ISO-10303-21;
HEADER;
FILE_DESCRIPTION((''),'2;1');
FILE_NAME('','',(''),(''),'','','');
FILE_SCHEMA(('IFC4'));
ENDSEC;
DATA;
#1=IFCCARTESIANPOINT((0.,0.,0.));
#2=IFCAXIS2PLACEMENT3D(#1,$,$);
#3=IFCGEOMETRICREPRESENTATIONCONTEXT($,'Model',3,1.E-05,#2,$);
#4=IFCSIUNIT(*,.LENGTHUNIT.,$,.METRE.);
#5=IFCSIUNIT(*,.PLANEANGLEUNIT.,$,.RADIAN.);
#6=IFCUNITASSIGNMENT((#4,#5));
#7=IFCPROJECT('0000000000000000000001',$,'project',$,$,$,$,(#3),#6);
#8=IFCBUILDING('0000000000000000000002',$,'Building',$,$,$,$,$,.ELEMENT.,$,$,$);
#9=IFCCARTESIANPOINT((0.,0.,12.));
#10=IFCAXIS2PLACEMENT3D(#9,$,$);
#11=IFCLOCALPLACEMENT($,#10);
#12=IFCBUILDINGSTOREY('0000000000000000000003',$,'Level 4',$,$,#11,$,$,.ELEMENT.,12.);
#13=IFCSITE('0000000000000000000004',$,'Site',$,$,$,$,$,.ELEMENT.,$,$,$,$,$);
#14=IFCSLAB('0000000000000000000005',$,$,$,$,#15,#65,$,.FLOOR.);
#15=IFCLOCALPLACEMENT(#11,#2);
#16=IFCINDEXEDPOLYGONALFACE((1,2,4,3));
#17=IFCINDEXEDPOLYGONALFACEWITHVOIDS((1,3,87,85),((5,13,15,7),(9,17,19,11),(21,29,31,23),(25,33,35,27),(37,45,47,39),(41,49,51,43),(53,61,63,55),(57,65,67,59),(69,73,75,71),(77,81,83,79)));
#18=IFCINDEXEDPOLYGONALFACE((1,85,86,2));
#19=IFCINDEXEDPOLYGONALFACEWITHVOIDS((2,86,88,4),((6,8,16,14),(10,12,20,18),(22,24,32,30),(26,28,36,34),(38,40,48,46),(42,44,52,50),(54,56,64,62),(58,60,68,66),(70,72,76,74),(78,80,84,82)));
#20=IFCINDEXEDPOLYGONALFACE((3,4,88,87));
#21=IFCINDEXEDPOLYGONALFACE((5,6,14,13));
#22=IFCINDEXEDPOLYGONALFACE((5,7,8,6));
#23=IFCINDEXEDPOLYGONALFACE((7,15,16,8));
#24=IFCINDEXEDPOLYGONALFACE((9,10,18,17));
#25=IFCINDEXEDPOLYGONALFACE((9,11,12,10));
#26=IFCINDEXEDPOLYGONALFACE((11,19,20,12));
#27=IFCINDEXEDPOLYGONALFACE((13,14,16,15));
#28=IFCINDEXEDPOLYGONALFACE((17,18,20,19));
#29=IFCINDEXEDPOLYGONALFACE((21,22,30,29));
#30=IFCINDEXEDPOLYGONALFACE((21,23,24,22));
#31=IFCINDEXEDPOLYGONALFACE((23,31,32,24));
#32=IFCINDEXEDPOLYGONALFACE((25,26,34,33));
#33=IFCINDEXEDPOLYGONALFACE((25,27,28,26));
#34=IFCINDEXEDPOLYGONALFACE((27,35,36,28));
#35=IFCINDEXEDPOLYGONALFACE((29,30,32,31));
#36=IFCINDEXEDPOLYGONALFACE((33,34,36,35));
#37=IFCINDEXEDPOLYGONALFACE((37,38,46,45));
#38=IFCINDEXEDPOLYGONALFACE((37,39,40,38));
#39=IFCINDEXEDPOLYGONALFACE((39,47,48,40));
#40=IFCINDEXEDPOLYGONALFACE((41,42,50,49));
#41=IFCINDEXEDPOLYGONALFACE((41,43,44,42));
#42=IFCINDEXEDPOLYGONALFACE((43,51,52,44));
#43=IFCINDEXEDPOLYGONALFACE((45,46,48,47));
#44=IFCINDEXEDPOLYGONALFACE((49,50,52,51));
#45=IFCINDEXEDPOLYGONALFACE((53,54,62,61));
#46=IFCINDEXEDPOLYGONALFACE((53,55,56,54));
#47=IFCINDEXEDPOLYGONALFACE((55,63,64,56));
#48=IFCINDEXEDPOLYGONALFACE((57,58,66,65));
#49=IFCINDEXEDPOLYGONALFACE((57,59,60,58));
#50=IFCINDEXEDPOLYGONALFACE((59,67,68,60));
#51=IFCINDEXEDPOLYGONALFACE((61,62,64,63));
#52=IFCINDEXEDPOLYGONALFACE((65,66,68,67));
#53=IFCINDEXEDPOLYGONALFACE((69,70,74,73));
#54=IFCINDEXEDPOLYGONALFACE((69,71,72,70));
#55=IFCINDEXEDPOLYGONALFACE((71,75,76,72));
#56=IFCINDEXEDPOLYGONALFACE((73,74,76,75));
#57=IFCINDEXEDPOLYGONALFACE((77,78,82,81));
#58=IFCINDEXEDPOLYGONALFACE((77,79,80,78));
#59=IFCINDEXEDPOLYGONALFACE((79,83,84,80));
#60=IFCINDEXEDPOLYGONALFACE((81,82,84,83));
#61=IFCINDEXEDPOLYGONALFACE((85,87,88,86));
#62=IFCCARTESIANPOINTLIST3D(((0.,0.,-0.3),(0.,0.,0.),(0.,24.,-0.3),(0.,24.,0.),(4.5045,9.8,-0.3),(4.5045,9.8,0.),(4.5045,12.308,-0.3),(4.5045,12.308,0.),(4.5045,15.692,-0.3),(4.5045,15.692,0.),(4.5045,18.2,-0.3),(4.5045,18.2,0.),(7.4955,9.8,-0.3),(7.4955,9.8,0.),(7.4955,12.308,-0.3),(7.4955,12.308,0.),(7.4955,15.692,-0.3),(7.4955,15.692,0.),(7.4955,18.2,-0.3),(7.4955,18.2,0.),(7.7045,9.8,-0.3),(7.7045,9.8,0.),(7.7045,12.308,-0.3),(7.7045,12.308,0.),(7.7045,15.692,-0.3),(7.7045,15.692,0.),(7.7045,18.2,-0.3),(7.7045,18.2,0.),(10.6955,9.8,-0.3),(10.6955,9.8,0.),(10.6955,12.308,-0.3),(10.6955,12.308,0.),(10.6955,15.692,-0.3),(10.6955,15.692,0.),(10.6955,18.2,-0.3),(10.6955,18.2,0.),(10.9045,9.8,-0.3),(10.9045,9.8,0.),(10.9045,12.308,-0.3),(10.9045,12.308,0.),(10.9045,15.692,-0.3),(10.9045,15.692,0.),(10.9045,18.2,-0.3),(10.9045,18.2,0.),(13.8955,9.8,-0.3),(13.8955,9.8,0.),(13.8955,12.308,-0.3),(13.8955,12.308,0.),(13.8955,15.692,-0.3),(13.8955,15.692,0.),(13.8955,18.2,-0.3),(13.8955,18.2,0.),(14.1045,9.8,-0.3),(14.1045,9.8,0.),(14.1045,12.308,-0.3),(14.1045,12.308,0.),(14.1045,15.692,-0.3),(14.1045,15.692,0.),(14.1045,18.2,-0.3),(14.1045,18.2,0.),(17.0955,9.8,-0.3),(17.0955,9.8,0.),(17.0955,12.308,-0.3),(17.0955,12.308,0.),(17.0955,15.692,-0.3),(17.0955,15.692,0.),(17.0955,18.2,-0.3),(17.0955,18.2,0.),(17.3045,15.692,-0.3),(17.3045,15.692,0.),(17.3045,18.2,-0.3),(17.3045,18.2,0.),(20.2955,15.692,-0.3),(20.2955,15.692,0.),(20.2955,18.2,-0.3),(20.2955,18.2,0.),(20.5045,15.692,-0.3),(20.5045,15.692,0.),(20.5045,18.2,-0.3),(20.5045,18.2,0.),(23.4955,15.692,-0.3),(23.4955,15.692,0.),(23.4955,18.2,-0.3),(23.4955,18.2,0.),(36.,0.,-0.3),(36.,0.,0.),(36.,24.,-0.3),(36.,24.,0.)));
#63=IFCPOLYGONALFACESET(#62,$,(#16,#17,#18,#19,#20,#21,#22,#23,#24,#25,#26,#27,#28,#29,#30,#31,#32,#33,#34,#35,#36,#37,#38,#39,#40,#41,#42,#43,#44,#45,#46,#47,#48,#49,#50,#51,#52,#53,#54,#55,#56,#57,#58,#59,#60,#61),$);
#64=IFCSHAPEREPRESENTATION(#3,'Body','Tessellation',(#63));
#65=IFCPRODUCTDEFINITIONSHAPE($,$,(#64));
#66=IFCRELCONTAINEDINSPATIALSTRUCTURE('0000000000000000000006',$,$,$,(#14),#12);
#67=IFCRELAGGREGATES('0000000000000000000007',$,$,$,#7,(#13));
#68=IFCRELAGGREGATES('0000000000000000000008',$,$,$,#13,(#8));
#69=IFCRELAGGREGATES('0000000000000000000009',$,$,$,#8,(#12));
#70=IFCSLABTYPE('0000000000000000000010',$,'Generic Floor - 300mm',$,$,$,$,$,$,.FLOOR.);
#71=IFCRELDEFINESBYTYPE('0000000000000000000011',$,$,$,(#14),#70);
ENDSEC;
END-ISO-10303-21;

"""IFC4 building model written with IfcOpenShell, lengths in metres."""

from ifc_helpers import new_model, si_unit, frame, origin, place, context, project, spatial, polyline, outline, extrude, type_object, element, save


model = new_model("IFC4")

# Units and contexts
model_context = context("Model", 3, precision=1e-05, world=origin())
ifc_project = project(units=[si_unit("LENGTHUNIT", "METRE"), si_unit("PLANEANGLEUNIT", "RADIAN")], contexts=[model_context])

# Site, building, storey
site = spatial("IfcSite", under=ifc_project, Name="Site", CompositionType="ELEMENT")
building = spatial("IfcBuilding", under=site, Name="Building", CompositionType="ELEMENT")
storey_placement = place(None, frame((0.0, 0.0, 12.0)))
storey = spatial("IfcBuildingStorey", under=building, at=storey_placement, Name="Level 4", CompositionType="ELEMENT", Elevation=12.0)

# Slab, openings
slab_type = type_object("IfcSlabType", Name="Generic Floor - 300mm", PredefinedType="FLOOR")
slab_placement = place(None, frame((0.0, 0.0, 12.0)))
slab = element("IfcSlab", 1, at=slab_placement, inside=storey, type_object=slab_type, PredefinedType="FLOOR", context=model_context, shape_type="SweptSolid", body=[
    extrude(outline(polyline([(0.0, 0.0), (36.0, 0.0), (36.0, 24.0), (0.0, 24.0), (0.0, 0.0)])), origin(), (0.0, 0.0, -1.0), 0.3),
])
opening_1_placement = place(None, frame((0.0, 0.0, 12.001)))
element("IfcOpeningElement", 2, at=opening_1_placement, cuts=slab, PredefinedType="OPENING", context=model_context, shape_type="SweptSolid", body=[
    extrude(outline(polyline([(4.5045, 9.8), (7.4955, 9.8), (7.4955, 12.308), (4.5045, 12.308), (4.5045, 9.8)])), origin(), (0.0, 0.0, -1.0), 0.302),
])
opening_2_placement = place(None, frame((0.0, 0.0, 12.001)))
element("IfcOpeningElement", 3, at=opening_2_placement, cuts=slab, PredefinedType="OPENING", context=model_context, shape_type="SweptSolid", body=[
    extrude(outline(polyline([(7.7045, 9.8), (10.6955, 9.8), (10.6955, 12.308), (7.7045, 12.308), (7.7045, 9.8)])), origin(), (0.0, 0.0, -1.0), 0.302),
])
opening_3_placement = place(None, frame((0.0, 0.0, 12.001)))
element("IfcOpeningElement", 4, at=opening_3_placement, cuts=slab, PredefinedType="OPENING", context=model_context, shape_type="SweptSolid", body=[
    extrude(outline(polyline([(10.9045, 9.8), (13.8955, 9.8), (13.8955, 12.308), (10.9045, 12.308), (10.9045, 9.8)])), origin(), (0.0, 0.0, -1.0), 0.302),
])
opening_4_placement = place(None, frame((0.0, 0.0, 12.001)))
element("IfcOpeningElement", 5, at=opening_4_placement, cuts=slab, PredefinedType="OPENING", context=model_context, shape_type="SweptSolid", body=[
    extrude(outline(polyline([(14.1045, 9.8), (17.0955, 9.8), (17.0955, 12.308), (14.1045, 12.308), (14.1045, 9.8)])), origin(), (0.0, 0.0, -1.0), 0.302),
])
opening_5_placement = place(None, frame((0.0, 0.0, 12.001)))
element("IfcOpeningElement", 6, at=opening_5_placement, cuts=slab, PredefinedType="OPENING", context=model_context, shape_type="SweptSolid", body=[
    extrude(outline(polyline([(7.4955, 18.2), (4.5045, 18.2), (4.5045, 15.692), (7.4955, 15.692), (7.4955, 18.2)])), origin(), (0.0, 0.0, -1.0), 0.302),
])
opening_6_placement = place(None, frame((0.0, 0.0, 12.001)))
element("IfcOpeningElement", 7, at=opening_6_placement, cuts=slab, PredefinedType="OPENING", context=model_context, shape_type="SweptSolid", body=[
    extrude(outline(polyline([(10.6955, 18.2), (7.7045, 18.2), (7.7045, 15.692), (10.6955, 15.692), (10.6955, 18.2)])), origin(), (0.0, 0.0, -1.0), 0.302),
])
opening_7_placement = place(None, frame((0.0, 0.0, 12.001)))
element("IfcOpeningElement", 8, at=opening_7_placement, cuts=slab, PredefinedType="OPENING", context=model_context, shape_type="SweptSolid", body=[
    extrude(outline(polyline([(13.8955, 18.2), (10.9045, 18.2), (10.9045, 15.692), (13.8955, 15.692), (13.8955, 18.2)])), origin(), (0.0, 0.0, -1.0), 0.302),
])
opening_8_placement = place(None, frame((0.0, 0.0, 12.001)))
element("IfcOpeningElement", 9, at=opening_8_placement, cuts=slab, PredefinedType="OPENING", context=model_context, shape_type="SweptSolid", body=[
    extrude(outline(polyline([(17.0955, 18.2), (14.1045, 18.2), (14.1045, 15.692), (17.0955, 15.692), (17.0955, 18.2)])), origin(), (0.0, 0.0, -1.0), 0.302),
])
opening_9_placement = place(None, frame((0.0, 0.0, 12.001)))
element("IfcOpeningElement", 10, at=opening_9_placement, cuts=slab, PredefinedType="OPENING", context=model_context, shape_type="SweptSolid", body=[
    extrude(outline(polyline([(20.2955, 18.2), (17.3045, 18.2), (17.3045, 15.692), (20.2955, 15.692), (20.2955, 18.2)])), origin(), (0.0, 0.0, -1.0), 0.302),
])
opening_10_placement = place(None, frame((0.0, 0.0, 12.001)))
element("IfcOpeningElement", 11, at=opening_10_placement, cuts=slab, PredefinedType="OPENING", context=model_context, shape_type="SweptSolid", body=[
    extrude(outline(polyline([(23.4955, 18.2), (20.5045, 18.2), (20.5045, 15.692), (23.4955, 15.692), (23.4955, 18.2)])), origin(), (0.0, 0.0, -1.0), 0.302),
])

save(model, "model.ifc")
